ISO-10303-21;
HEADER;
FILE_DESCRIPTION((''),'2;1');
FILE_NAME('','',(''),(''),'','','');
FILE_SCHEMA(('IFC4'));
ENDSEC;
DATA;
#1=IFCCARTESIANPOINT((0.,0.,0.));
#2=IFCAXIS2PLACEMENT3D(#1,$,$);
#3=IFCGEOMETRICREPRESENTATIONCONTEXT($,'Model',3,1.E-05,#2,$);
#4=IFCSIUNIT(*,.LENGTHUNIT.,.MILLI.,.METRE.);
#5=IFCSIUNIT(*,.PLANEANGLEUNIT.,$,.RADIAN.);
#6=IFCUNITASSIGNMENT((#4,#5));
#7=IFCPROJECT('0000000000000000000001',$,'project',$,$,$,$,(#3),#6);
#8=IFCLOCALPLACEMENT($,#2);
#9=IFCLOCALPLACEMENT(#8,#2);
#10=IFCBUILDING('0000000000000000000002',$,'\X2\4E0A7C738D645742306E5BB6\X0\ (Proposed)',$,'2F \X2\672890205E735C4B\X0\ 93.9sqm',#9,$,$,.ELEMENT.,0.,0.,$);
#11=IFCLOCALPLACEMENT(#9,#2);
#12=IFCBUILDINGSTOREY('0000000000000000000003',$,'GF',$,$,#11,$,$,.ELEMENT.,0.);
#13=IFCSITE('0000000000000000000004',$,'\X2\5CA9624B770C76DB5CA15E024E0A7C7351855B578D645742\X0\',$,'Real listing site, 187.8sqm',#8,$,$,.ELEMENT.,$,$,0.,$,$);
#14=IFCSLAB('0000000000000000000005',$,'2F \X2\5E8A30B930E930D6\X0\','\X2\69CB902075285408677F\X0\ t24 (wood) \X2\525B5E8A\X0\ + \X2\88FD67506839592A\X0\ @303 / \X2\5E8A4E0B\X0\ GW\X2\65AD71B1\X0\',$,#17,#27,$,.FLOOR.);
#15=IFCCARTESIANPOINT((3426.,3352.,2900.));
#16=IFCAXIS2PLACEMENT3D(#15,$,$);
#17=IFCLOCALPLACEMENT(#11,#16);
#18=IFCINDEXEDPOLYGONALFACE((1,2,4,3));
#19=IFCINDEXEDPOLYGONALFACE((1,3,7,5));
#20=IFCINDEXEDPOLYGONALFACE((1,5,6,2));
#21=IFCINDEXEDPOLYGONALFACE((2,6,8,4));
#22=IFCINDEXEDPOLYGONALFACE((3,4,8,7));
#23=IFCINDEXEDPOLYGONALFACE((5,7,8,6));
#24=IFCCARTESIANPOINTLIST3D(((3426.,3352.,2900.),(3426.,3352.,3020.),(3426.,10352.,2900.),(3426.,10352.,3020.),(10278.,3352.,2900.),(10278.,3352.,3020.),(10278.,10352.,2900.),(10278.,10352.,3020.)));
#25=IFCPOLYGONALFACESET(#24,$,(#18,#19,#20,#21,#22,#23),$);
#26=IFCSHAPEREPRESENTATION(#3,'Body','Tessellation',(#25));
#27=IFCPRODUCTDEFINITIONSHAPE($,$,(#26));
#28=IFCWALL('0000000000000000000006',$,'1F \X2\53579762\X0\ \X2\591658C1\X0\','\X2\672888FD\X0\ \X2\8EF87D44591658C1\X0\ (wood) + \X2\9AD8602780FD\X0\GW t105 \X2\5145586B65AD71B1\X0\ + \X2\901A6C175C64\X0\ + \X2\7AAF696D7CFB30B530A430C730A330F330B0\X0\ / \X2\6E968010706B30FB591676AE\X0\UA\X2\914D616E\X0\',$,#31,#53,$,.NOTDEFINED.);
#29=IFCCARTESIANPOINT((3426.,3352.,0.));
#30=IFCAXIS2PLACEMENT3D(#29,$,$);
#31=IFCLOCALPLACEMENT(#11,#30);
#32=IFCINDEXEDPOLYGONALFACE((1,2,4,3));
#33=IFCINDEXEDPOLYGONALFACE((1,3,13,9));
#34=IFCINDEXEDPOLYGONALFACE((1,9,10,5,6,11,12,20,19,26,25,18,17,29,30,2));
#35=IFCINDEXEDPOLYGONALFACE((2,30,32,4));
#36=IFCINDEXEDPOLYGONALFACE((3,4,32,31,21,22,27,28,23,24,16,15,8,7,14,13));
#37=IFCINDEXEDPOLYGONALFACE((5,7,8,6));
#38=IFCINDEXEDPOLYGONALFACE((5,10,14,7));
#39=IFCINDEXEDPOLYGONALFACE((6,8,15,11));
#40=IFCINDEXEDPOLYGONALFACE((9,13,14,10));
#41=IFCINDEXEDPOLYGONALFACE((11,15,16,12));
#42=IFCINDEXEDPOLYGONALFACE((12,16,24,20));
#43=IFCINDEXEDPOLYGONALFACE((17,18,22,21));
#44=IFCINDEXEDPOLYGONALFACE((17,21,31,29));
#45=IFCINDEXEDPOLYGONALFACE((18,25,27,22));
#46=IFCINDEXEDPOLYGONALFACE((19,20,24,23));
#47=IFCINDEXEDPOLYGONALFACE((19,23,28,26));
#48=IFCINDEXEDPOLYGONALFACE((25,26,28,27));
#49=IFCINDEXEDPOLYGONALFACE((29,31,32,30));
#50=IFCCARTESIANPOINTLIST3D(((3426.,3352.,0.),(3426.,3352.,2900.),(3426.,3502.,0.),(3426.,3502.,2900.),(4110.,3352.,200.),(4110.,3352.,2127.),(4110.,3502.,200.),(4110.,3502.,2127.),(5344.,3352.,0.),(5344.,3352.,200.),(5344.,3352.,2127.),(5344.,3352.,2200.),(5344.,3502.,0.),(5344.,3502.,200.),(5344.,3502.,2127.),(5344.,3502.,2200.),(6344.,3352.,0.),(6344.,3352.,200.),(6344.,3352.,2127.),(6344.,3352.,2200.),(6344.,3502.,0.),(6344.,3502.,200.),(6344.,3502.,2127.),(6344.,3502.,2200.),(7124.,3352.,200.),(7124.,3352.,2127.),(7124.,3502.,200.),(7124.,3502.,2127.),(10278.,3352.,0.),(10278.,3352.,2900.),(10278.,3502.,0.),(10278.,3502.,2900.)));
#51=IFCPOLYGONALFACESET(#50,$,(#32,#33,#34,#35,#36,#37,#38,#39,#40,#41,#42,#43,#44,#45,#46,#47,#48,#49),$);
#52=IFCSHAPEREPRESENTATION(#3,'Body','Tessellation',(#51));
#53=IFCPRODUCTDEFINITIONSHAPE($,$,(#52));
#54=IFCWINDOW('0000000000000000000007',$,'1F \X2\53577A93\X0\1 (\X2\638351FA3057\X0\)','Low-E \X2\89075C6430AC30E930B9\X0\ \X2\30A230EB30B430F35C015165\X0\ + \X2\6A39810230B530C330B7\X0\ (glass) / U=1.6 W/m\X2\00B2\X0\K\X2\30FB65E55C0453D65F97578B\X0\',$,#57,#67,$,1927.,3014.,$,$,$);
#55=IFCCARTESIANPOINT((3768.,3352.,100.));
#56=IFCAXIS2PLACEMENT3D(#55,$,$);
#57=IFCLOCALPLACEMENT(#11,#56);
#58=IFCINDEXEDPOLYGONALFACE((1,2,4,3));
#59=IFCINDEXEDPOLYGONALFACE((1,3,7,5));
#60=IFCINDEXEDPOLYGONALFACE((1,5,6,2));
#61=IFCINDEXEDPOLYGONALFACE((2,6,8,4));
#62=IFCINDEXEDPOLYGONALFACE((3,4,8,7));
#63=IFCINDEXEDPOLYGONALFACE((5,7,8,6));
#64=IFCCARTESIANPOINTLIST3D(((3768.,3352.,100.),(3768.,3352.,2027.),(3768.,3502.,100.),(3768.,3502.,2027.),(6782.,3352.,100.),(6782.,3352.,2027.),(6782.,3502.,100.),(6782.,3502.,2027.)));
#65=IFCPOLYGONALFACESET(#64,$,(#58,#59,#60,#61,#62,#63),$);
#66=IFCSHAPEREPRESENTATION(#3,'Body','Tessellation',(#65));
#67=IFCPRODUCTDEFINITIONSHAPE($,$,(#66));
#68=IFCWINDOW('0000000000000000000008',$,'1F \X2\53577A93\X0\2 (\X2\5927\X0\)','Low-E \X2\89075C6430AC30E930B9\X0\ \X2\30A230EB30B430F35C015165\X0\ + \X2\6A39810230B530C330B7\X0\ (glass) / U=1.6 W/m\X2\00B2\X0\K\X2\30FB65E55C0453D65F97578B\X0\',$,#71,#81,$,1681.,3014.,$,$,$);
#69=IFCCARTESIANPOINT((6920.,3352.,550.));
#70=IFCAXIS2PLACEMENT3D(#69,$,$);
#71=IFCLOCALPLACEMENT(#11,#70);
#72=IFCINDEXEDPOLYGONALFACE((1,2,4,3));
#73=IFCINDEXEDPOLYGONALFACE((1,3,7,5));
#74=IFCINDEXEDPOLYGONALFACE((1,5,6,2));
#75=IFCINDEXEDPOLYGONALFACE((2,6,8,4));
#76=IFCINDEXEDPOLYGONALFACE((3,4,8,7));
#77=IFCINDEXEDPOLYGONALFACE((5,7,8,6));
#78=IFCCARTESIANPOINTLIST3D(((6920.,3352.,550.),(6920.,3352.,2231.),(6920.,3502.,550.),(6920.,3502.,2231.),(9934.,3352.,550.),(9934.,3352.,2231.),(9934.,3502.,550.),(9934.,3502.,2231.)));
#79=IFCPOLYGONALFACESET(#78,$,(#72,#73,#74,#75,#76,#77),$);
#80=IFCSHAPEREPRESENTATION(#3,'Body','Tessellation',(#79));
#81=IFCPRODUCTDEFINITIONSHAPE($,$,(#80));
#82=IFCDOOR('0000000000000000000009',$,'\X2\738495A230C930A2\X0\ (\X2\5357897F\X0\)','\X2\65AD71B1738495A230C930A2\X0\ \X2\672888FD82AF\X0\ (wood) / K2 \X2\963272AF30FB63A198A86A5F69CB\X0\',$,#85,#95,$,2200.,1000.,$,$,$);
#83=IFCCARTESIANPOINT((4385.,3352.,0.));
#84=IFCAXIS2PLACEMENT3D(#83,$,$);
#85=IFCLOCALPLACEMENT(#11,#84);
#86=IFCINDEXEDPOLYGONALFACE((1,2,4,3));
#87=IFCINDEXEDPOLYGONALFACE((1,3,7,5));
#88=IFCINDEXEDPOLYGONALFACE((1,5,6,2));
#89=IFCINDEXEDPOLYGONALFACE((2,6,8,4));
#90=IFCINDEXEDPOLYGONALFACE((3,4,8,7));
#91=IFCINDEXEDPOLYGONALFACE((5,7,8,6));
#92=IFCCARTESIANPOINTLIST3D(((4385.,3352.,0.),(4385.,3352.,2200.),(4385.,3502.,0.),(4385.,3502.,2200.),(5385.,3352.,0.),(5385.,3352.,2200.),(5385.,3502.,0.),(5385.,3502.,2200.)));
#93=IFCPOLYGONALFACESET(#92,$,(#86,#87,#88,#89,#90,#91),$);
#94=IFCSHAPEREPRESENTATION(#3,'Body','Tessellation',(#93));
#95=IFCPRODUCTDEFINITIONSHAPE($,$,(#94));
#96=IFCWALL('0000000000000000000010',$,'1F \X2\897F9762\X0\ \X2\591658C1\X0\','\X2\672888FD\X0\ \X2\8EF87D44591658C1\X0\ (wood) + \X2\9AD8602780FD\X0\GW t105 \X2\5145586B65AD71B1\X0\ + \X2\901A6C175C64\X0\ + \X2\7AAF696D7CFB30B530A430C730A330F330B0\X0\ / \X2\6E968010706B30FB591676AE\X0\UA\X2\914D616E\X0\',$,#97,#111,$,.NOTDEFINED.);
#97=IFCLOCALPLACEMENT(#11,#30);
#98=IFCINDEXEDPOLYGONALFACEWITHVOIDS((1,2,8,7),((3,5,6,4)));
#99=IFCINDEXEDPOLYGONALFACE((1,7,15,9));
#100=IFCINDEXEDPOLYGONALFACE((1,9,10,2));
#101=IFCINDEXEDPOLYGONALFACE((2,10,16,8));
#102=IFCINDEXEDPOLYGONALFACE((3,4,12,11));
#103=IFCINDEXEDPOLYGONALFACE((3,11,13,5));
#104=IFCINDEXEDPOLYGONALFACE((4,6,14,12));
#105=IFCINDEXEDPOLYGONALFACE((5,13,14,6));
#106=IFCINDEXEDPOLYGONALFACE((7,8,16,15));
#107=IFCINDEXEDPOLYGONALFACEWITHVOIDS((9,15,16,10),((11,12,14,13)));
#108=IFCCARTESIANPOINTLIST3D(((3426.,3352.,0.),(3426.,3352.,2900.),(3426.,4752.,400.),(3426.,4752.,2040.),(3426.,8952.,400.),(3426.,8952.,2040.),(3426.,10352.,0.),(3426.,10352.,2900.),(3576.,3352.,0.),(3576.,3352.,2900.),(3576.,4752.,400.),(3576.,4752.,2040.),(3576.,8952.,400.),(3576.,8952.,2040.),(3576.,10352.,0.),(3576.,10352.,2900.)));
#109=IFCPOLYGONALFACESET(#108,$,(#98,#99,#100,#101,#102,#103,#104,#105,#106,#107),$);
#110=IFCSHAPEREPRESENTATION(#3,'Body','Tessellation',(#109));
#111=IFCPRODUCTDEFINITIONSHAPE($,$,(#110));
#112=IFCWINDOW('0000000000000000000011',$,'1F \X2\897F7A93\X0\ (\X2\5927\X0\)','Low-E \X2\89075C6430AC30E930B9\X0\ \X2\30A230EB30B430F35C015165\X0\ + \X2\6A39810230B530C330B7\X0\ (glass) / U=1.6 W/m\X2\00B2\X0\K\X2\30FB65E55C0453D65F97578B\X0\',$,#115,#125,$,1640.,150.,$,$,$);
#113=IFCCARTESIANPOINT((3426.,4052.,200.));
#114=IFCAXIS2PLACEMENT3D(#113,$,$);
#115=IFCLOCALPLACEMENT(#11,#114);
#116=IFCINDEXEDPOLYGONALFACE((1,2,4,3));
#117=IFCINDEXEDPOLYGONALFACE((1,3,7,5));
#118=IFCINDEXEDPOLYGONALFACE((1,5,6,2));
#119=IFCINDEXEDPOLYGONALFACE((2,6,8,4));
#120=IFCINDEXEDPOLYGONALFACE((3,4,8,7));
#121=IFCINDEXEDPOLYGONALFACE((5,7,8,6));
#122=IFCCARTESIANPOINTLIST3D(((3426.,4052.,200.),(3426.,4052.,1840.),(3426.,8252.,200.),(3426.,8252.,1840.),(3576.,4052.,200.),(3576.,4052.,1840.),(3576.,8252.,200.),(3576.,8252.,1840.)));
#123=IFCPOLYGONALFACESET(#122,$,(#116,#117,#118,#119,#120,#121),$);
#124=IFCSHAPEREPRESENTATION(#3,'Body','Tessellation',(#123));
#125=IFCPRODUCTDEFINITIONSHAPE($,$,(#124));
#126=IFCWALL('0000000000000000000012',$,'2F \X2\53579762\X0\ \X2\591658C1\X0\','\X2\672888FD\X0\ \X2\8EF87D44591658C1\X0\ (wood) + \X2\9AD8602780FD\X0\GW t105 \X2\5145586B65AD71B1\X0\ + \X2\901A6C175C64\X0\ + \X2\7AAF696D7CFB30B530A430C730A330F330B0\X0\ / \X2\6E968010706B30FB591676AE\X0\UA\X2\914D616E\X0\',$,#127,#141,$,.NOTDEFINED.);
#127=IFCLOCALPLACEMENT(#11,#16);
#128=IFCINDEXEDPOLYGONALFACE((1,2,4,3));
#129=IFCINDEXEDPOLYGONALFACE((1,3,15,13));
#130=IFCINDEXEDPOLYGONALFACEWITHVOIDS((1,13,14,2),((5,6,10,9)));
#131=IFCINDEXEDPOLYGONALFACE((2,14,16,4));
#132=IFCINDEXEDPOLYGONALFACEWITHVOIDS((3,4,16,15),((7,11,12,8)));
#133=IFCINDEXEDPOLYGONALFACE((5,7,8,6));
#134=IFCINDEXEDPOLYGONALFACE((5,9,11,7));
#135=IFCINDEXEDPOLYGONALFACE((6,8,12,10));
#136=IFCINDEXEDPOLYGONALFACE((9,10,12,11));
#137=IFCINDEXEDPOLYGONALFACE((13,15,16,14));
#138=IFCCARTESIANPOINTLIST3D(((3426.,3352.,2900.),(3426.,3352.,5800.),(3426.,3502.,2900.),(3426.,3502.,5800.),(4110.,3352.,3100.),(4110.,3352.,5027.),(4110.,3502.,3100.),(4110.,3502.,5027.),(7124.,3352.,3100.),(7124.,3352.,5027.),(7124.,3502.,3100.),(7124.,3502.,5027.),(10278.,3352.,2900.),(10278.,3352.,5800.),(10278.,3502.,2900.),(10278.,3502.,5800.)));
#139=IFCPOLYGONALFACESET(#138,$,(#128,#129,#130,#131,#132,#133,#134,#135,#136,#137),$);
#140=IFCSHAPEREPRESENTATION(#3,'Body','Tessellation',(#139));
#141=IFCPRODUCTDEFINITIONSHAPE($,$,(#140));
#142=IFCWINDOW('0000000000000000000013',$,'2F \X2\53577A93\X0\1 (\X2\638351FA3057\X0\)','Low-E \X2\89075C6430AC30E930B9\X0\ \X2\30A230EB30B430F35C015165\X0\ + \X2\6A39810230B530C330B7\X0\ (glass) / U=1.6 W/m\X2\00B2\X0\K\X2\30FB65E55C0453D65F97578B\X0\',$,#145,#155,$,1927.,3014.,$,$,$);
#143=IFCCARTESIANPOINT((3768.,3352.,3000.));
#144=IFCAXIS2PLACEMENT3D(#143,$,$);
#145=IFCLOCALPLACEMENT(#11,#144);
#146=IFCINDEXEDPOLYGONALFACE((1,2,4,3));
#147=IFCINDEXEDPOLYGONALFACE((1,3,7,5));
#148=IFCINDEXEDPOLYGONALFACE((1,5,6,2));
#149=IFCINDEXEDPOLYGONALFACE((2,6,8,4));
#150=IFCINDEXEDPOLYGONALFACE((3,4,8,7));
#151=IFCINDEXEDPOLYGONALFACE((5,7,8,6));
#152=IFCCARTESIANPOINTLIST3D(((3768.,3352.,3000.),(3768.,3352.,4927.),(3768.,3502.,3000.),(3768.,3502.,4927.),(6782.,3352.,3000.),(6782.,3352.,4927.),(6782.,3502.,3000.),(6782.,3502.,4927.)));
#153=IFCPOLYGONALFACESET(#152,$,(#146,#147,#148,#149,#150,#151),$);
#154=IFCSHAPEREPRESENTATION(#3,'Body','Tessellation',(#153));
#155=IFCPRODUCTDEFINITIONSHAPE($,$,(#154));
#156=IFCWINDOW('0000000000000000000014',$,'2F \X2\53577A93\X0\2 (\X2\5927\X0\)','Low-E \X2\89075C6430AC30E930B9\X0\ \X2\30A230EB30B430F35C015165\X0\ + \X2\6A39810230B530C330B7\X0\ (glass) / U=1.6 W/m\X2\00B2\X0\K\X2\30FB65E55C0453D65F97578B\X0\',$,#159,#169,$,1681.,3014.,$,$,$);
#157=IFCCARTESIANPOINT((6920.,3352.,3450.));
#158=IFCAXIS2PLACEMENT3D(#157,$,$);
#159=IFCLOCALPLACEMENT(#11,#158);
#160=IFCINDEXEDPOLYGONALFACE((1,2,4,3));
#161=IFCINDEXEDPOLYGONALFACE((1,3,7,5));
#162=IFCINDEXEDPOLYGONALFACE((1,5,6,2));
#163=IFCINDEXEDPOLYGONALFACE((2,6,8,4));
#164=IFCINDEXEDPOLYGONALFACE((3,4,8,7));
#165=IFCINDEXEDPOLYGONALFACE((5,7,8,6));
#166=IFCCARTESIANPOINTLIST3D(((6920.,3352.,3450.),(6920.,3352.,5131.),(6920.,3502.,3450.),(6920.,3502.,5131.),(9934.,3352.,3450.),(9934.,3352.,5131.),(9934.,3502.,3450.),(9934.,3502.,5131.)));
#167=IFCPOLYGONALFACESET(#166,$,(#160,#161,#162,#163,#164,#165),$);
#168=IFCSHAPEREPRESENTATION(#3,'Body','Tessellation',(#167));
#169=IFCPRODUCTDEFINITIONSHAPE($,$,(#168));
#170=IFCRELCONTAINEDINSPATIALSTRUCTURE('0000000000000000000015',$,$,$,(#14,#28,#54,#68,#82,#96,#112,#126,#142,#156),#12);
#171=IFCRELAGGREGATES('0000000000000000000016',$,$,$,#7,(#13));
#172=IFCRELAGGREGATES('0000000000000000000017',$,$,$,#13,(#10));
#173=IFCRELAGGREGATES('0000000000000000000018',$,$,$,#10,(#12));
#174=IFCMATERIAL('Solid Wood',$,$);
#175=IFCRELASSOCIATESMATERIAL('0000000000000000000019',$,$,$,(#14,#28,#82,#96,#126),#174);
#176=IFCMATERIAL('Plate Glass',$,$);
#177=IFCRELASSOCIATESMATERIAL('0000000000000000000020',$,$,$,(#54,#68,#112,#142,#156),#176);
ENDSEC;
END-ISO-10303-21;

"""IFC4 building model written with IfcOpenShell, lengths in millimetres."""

from ifc_helpers import new_model, si_unit, frame, frame_2d, origin, place, context, project, spatial, rectangle, extrude, material, element, fill, save


model = new_model("IFC4")

# Units and contexts
model_context = context("Model", 3, precision=1e-05, world=origin())
ifc_project = project(units=[si_unit("LENGTHUNIT", "METRE", prefix="MILLI"), si_unit("PLANEANGLEUNIT", "RADIAN")], contexts=[model_context])

# Site, building, storey
site_placement = place(None, origin())
site = spatial("IfcSite", under=ifc_project, at=site_placement, Name="岩手県盛岡市上米内字赤坂", ObjectType="Real listing site, 187.8sqm", CompositionType="ELEMENT", RefElevation=0.0)
building_placement = place(site_placement, origin())
building = spatial("IfcBuilding", under=site, at=building_placement, Name="上米赤坂の家 (Proposed)", ObjectType="2F 木造平屋 93.9sqm", CompositionType="ELEMENT", ElevationOfRefHeight=0.0, ElevationOfTerrain=0.0)
storey_placement = place(building_placement, origin())
storey = spatial("IfcBuildingStorey", under=building, at=storey_placement, Name="GF", CompositionType="ELEMENT", Elevation=0.0)

# Slab
ifc_material_1 = material(Name="Solid Wood")
slab_1_placement = place(storey_placement, frame((3426.0, 3352.0, 2900.0)))
element("IfcSlab", 1, at=slab_1_placement, inside=storey, material=ifc_material_1, Name="2F 床スラブ", Description="構造用合板 t24 (wood) 剛床 + 製材根太 @303 / 床下 GW断熱", PredefinedType="FLOOR", context=model_context, shape_type="SweptSolid", body=[
    extrude(rectangle(XDim=6852.0, YDim=7000.0, at=frame_2d((3426.0, 3500.0))), frame((3426.0, 3352.0, 2900.0)), (0.0, 0.0, 1.0), 120.0),
])

# Wall, openings, windows, door
wall_1_placement = place(storey_placement, frame((3426.0, 3352.0, 0.0)))
wall_1 = element("IfcWall", 2, at=wall_1_placement, inside=storey, material=ifc_material_1, Name="1F 南面 外壁", Description="木製 軸組外壁 (wood) + 高性能GW t105 充填断熱 + 通気層 + 窯業系サイディング / 準耐火・外皮UA配慮", PredefinedType="NOTDEFINED", context=model_context, shape_type="SweptSolid", body=[
    extrude(rectangle(XDim=6852.0, YDim=150.0, at=frame_2d((3426.0, 75.0))), frame((3426.0, 3352.0, 0.0)), (0.0, 0.0, 1.0), 2900.0),
])
opening_1_placement = place(storey_placement, frame((3768.0, 3352.0, 100.0)))
opening_1 = element("IfcOpeningElement", 3, at=opening_1_placement, cuts=wall_1, PredefinedType="NOTDEFINED", context=model_context, shape_type="SweptSolid", body=[
    extrude(rectangle(XDim=3014.0, YDim=150.0, at=frame_2d((1507.0, 75.0))), frame((3768.0, 3352.0, 100.0)), (0.0, 0.0, 1.0), 1927.0),
])
opening_2_placement = place(storey_placement, frame((6920.0, 3352.0, 550.0)))
opening_2 = element("IfcOpeningElement", 4, at=opening_2_placement, cuts=wall_1, PredefinedType="NOTDEFINED", context=model_context, shape_type="SweptSolid", body=[
    extrude(rectangle(XDim=3014.0, YDim=150.0, at=frame_2d((1507.0, 75.0))), frame((6920.0, 3352.0, 550.0)), (0.0, 0.0, 1.0), 1681.0),
])
opening_3_placement = place(storey_placement, frame((4385.0, 3352.0, 0.0)))
opening_3 = element("IfcOpeningElement", 5, at=opening_3_placement, cuts=wall_1, PredefinedType="NOTDEFINED", context=model_context, shape_type="SweptSolid", body=[
    extrude(rectangle(XDim=1000.0, YDim=150.0, at=frame_2d((500.0, 75.0))), frame((4385.0, 3352.0, 0.0)), (0.0, 0.0, 1.0), 2200.0),
])
ifc_material_2 = material(Name="Plate Glass")
window_1_placement = place(storey_placement, frame((3768.0, 3352.0, 100.0)))
window_1 = element("IfcWindow", 6, at=window_1_placement, inside=storey, material=ifc_material_2, Name="1F 南窓1 (掃出し)", Description="Low-E 複層ガラス アルゴン封入 + 樹脂サッシ (glass) / U=1.6 W/m²K・日射取得型", OverallHeight=1927.0, OverallWidth=3014.0, context=model_context, shape_type="SweptSolid", body=[
    extrude(rectangle(XDim=3014.0, YDim=150.0, at=frame_2d((1507.0, 75.0))), frame((3768.0, 3352.0, 100.0)), (0.0, 0.0, 1.0), 1927.0),
])
fill(opening_1, window_1)
window_2_placement = place(storey_placement, frame((6920.0, 3352.0, 550.0)))
window_2 = element("IfcWindow", 7, at=window_2_placement, inside=storey, material=ifc_material_2, Name="1F 南窓2 (大)", Description="Low-E 複層ガラス アルゴン封入 + 樹脂サッシ (glass) / U=1.6 W/m²K・日射取得型", OverallHeight=1681.0, OverallWidth=3014.0, context=model_context, shape_type="SweptSolid", body=[
    extrude(rectangle(XDim=3014.0, YDim=150.0, at=frame_2d((1507.0, 75.0))), frame((6920.0, 3352.0, 550.0)), (0.0, 0.0, 1.0), 1681.0),
])
fill(opening_2, window_2)
door_placement = place(storey_placement, frame((4385.0, 3352.0, 0.0)))
door = element("IfcDoor", 8, at=door_placement, inside=storey, material=ifc_material_1, Name="玄関ドア (南西)", Description="断熱玄関ドア 木製芯 (wood) / K2 防犯・採風機構", OverallHeight=2200.0, OverallWidth=1000.0, context=model_context, shape_type="SweptSolid", body=[
    extrude(rectangle(XDim=1000.0, YDim=150.0, at=frame_2d((500.0, 75.0))), frame((4385.0, 3352.0, 0.0)), (0.0, 0.0, 1.0), 2200.0),
])
fill(opening_3, door)

# Wall, opening, window
wall_2_placement = place(storey_placement, frame((3426.0, 3352.0, 0.0)))
wall_2 = element("IfcWall", 9, at=wall_2_placement, inside=storey, material=ifc_material_1, Name="1F 西面 外壁", Description="木製 軸組外壁 (wood) + 高性能GW t105 充填断熱 + 通気層 + 窯業系サイディング / 準耐火・外皮UA配慮", PredefinedType="NOTDEFINED", context=model_context, shape_type="SweptSolid", body=[
    extrude(rectangle(XDim=150.0, YDim=7000.0, at=frame_2d((75.0, 3500.0))), frame((3426.0, 3352.0, 0.0)), (0.0, 0.0, 1.0), 2900.0),
])
opening_4_placement = place(storey_placement, frame((3426.0, 4052.0, 200.0)))
opening_4 = element("IfcOpeningElement", 10, at=opening_4_placement, cuts=wall_2, PredefinedType="NOTDEFINED", context=model_context, shape_type="SweptSolid", body=[
    extrude(rectangle(XDim=150.0, YDim=4200.0, at=frame_2d((75.0, 2100.0))), frame((3426.0, 4052.0, 200.0)), (0.0, 0.0, 1.0), 1640.0),
])
window_3_placement = place(storey_placement, frame((3426.0, 4052.0, 200.0)))
window_3 = element("IfcWindow", 11, at=window_3_placement, inside=storey, material=ifc_material_2, Name="1F 西窓 (大)", Description="Low-E 複層ガラス アルゴン封入 + 樹脂サッシ (glass) / U=1.6 W/m²K・日射取得型", OverallHeight=1640.0, OverallWidth=150.0, context=model_context, shape_type="SweptSolid", body=[
    extrude(rectangle(XDim=150.0, YDim=4200.0, at=frame_2d((75.0, 2100.0))), frame((3426.0, 4052.0, 200.0)), (0.0, 0.0, 1.0), 1640.0),
])
fill(opening_4, window_3)

# Wall, openings, windows
wall_3_placement = place(storey_placement, frame((3426.0, 3352.0, 2900.0)))
wall_3 = element("IfcWall", 12, at=wall_3_placement, inside=storey, material=ifc_material_1, Name="2F 南面 外壁", Description="木製 軸組外壁 (wood) + 高性能GW t105 充填断熱 + 通気層 + 窯業系サイディング / 準耐火・外皮UA配慮", PredefinedType="NOTDEFINED", context=model_context, shape_type="SweptSolid", body=[
    extrude(rectangle(XDim=6852.0, YDim=150.0, at=frame_2d((3426.0, 75.0))), frame((3426.0, 3352.0, 2900.0)), (0.0, 0.0, 1.0), 2900.0),
])
opening_5_placement = place(storey_placement, frame((3768.0, 3352.0, 3000.0)))
opening_5 = element("IfcOpeningElement", 13, at=opening_5_placement, cuts=wall_3, PredefinedType="NOTDEFINED", context=model_context, shape_type="SweptSolid", body=[
    extrude(rectangle(XDim=3014.0, YDim=150.0, at=frame_2d((1507.0, 75.0))), frame((3768.0, 3352.0, 3000.0)), (0.0, 0.0, 1.0), 1927.0),
])
opening_6_placement = place(storey_placement, frame((6920.0, 3352.0, 3450.0)))
opening_6 = element("IfcOpeningElement", 14, at=opening_6_placement, cuts=wall_3, PredefinedType="NOTDEFINED", context=model_context, shape_type="SweptSolid", body=[
    extrude(rectangle(XDim=3014.0, YDim=150.0, at=frame_2d((1507.0, 75.0))), frame((6920.0, 3352.0, 3450.0)), (0.0, 0.0, 1.0), 1681.0),
])
window_4_placement = place(storey_placement, frame((3768.0, 3352.0, 3000.0)))
window_4 = element("IfcWindow", 15, at=window_4_placement, inside=storey, material=ifc_material_2, Name="2F 南窓1 (掃出し)", Description="Low-E 複層ガラス アルゴン封入 + 樹脂サッシ (glass) / U=1.6 W/m²K・日射取得型", OverallHeight=1927.0, OverallWidth=3014.0, context=model_context, shape_type="SweptSolid", body=[
    extrude(rectangle(XDim=3014.0, YDim=150.0, at=frame_2d((1507.0, 75.0))), frame((3768.0, 3352.0, 3000.0)), (0.0, 0.0, 1.0), 1927.0),
])
fill(opening_5, window_4)
window_5_placement = place(storey_placement, frame((6920.0, 3352.0, 3450.0)))
window_5 = element("IfcWindow", 16, at=window_5_placement, inside=storey, material=ifc_material_2, Name="2F 南窓2 (大)", Description="Low-E 複層ガラス アルゴン封入 + 樹脂サッシ (glass) / U=1.6 W/m²K・日射取得型", OverallHeight=1681.0, OverallWidth=3014.0, context=model_context, shape_type="SweptSolid", body=[
    extrude(rectangle(XDim=3014.0, YDim=150.0, at=frame_2d((1507.0, 75.0))), frame((6920.0, 3352.0, 3450.0)), (0.0, 0.0, 1.0), 1681.0),
])
fill(opening_6, window_5)

save(model, "model.ifc")
